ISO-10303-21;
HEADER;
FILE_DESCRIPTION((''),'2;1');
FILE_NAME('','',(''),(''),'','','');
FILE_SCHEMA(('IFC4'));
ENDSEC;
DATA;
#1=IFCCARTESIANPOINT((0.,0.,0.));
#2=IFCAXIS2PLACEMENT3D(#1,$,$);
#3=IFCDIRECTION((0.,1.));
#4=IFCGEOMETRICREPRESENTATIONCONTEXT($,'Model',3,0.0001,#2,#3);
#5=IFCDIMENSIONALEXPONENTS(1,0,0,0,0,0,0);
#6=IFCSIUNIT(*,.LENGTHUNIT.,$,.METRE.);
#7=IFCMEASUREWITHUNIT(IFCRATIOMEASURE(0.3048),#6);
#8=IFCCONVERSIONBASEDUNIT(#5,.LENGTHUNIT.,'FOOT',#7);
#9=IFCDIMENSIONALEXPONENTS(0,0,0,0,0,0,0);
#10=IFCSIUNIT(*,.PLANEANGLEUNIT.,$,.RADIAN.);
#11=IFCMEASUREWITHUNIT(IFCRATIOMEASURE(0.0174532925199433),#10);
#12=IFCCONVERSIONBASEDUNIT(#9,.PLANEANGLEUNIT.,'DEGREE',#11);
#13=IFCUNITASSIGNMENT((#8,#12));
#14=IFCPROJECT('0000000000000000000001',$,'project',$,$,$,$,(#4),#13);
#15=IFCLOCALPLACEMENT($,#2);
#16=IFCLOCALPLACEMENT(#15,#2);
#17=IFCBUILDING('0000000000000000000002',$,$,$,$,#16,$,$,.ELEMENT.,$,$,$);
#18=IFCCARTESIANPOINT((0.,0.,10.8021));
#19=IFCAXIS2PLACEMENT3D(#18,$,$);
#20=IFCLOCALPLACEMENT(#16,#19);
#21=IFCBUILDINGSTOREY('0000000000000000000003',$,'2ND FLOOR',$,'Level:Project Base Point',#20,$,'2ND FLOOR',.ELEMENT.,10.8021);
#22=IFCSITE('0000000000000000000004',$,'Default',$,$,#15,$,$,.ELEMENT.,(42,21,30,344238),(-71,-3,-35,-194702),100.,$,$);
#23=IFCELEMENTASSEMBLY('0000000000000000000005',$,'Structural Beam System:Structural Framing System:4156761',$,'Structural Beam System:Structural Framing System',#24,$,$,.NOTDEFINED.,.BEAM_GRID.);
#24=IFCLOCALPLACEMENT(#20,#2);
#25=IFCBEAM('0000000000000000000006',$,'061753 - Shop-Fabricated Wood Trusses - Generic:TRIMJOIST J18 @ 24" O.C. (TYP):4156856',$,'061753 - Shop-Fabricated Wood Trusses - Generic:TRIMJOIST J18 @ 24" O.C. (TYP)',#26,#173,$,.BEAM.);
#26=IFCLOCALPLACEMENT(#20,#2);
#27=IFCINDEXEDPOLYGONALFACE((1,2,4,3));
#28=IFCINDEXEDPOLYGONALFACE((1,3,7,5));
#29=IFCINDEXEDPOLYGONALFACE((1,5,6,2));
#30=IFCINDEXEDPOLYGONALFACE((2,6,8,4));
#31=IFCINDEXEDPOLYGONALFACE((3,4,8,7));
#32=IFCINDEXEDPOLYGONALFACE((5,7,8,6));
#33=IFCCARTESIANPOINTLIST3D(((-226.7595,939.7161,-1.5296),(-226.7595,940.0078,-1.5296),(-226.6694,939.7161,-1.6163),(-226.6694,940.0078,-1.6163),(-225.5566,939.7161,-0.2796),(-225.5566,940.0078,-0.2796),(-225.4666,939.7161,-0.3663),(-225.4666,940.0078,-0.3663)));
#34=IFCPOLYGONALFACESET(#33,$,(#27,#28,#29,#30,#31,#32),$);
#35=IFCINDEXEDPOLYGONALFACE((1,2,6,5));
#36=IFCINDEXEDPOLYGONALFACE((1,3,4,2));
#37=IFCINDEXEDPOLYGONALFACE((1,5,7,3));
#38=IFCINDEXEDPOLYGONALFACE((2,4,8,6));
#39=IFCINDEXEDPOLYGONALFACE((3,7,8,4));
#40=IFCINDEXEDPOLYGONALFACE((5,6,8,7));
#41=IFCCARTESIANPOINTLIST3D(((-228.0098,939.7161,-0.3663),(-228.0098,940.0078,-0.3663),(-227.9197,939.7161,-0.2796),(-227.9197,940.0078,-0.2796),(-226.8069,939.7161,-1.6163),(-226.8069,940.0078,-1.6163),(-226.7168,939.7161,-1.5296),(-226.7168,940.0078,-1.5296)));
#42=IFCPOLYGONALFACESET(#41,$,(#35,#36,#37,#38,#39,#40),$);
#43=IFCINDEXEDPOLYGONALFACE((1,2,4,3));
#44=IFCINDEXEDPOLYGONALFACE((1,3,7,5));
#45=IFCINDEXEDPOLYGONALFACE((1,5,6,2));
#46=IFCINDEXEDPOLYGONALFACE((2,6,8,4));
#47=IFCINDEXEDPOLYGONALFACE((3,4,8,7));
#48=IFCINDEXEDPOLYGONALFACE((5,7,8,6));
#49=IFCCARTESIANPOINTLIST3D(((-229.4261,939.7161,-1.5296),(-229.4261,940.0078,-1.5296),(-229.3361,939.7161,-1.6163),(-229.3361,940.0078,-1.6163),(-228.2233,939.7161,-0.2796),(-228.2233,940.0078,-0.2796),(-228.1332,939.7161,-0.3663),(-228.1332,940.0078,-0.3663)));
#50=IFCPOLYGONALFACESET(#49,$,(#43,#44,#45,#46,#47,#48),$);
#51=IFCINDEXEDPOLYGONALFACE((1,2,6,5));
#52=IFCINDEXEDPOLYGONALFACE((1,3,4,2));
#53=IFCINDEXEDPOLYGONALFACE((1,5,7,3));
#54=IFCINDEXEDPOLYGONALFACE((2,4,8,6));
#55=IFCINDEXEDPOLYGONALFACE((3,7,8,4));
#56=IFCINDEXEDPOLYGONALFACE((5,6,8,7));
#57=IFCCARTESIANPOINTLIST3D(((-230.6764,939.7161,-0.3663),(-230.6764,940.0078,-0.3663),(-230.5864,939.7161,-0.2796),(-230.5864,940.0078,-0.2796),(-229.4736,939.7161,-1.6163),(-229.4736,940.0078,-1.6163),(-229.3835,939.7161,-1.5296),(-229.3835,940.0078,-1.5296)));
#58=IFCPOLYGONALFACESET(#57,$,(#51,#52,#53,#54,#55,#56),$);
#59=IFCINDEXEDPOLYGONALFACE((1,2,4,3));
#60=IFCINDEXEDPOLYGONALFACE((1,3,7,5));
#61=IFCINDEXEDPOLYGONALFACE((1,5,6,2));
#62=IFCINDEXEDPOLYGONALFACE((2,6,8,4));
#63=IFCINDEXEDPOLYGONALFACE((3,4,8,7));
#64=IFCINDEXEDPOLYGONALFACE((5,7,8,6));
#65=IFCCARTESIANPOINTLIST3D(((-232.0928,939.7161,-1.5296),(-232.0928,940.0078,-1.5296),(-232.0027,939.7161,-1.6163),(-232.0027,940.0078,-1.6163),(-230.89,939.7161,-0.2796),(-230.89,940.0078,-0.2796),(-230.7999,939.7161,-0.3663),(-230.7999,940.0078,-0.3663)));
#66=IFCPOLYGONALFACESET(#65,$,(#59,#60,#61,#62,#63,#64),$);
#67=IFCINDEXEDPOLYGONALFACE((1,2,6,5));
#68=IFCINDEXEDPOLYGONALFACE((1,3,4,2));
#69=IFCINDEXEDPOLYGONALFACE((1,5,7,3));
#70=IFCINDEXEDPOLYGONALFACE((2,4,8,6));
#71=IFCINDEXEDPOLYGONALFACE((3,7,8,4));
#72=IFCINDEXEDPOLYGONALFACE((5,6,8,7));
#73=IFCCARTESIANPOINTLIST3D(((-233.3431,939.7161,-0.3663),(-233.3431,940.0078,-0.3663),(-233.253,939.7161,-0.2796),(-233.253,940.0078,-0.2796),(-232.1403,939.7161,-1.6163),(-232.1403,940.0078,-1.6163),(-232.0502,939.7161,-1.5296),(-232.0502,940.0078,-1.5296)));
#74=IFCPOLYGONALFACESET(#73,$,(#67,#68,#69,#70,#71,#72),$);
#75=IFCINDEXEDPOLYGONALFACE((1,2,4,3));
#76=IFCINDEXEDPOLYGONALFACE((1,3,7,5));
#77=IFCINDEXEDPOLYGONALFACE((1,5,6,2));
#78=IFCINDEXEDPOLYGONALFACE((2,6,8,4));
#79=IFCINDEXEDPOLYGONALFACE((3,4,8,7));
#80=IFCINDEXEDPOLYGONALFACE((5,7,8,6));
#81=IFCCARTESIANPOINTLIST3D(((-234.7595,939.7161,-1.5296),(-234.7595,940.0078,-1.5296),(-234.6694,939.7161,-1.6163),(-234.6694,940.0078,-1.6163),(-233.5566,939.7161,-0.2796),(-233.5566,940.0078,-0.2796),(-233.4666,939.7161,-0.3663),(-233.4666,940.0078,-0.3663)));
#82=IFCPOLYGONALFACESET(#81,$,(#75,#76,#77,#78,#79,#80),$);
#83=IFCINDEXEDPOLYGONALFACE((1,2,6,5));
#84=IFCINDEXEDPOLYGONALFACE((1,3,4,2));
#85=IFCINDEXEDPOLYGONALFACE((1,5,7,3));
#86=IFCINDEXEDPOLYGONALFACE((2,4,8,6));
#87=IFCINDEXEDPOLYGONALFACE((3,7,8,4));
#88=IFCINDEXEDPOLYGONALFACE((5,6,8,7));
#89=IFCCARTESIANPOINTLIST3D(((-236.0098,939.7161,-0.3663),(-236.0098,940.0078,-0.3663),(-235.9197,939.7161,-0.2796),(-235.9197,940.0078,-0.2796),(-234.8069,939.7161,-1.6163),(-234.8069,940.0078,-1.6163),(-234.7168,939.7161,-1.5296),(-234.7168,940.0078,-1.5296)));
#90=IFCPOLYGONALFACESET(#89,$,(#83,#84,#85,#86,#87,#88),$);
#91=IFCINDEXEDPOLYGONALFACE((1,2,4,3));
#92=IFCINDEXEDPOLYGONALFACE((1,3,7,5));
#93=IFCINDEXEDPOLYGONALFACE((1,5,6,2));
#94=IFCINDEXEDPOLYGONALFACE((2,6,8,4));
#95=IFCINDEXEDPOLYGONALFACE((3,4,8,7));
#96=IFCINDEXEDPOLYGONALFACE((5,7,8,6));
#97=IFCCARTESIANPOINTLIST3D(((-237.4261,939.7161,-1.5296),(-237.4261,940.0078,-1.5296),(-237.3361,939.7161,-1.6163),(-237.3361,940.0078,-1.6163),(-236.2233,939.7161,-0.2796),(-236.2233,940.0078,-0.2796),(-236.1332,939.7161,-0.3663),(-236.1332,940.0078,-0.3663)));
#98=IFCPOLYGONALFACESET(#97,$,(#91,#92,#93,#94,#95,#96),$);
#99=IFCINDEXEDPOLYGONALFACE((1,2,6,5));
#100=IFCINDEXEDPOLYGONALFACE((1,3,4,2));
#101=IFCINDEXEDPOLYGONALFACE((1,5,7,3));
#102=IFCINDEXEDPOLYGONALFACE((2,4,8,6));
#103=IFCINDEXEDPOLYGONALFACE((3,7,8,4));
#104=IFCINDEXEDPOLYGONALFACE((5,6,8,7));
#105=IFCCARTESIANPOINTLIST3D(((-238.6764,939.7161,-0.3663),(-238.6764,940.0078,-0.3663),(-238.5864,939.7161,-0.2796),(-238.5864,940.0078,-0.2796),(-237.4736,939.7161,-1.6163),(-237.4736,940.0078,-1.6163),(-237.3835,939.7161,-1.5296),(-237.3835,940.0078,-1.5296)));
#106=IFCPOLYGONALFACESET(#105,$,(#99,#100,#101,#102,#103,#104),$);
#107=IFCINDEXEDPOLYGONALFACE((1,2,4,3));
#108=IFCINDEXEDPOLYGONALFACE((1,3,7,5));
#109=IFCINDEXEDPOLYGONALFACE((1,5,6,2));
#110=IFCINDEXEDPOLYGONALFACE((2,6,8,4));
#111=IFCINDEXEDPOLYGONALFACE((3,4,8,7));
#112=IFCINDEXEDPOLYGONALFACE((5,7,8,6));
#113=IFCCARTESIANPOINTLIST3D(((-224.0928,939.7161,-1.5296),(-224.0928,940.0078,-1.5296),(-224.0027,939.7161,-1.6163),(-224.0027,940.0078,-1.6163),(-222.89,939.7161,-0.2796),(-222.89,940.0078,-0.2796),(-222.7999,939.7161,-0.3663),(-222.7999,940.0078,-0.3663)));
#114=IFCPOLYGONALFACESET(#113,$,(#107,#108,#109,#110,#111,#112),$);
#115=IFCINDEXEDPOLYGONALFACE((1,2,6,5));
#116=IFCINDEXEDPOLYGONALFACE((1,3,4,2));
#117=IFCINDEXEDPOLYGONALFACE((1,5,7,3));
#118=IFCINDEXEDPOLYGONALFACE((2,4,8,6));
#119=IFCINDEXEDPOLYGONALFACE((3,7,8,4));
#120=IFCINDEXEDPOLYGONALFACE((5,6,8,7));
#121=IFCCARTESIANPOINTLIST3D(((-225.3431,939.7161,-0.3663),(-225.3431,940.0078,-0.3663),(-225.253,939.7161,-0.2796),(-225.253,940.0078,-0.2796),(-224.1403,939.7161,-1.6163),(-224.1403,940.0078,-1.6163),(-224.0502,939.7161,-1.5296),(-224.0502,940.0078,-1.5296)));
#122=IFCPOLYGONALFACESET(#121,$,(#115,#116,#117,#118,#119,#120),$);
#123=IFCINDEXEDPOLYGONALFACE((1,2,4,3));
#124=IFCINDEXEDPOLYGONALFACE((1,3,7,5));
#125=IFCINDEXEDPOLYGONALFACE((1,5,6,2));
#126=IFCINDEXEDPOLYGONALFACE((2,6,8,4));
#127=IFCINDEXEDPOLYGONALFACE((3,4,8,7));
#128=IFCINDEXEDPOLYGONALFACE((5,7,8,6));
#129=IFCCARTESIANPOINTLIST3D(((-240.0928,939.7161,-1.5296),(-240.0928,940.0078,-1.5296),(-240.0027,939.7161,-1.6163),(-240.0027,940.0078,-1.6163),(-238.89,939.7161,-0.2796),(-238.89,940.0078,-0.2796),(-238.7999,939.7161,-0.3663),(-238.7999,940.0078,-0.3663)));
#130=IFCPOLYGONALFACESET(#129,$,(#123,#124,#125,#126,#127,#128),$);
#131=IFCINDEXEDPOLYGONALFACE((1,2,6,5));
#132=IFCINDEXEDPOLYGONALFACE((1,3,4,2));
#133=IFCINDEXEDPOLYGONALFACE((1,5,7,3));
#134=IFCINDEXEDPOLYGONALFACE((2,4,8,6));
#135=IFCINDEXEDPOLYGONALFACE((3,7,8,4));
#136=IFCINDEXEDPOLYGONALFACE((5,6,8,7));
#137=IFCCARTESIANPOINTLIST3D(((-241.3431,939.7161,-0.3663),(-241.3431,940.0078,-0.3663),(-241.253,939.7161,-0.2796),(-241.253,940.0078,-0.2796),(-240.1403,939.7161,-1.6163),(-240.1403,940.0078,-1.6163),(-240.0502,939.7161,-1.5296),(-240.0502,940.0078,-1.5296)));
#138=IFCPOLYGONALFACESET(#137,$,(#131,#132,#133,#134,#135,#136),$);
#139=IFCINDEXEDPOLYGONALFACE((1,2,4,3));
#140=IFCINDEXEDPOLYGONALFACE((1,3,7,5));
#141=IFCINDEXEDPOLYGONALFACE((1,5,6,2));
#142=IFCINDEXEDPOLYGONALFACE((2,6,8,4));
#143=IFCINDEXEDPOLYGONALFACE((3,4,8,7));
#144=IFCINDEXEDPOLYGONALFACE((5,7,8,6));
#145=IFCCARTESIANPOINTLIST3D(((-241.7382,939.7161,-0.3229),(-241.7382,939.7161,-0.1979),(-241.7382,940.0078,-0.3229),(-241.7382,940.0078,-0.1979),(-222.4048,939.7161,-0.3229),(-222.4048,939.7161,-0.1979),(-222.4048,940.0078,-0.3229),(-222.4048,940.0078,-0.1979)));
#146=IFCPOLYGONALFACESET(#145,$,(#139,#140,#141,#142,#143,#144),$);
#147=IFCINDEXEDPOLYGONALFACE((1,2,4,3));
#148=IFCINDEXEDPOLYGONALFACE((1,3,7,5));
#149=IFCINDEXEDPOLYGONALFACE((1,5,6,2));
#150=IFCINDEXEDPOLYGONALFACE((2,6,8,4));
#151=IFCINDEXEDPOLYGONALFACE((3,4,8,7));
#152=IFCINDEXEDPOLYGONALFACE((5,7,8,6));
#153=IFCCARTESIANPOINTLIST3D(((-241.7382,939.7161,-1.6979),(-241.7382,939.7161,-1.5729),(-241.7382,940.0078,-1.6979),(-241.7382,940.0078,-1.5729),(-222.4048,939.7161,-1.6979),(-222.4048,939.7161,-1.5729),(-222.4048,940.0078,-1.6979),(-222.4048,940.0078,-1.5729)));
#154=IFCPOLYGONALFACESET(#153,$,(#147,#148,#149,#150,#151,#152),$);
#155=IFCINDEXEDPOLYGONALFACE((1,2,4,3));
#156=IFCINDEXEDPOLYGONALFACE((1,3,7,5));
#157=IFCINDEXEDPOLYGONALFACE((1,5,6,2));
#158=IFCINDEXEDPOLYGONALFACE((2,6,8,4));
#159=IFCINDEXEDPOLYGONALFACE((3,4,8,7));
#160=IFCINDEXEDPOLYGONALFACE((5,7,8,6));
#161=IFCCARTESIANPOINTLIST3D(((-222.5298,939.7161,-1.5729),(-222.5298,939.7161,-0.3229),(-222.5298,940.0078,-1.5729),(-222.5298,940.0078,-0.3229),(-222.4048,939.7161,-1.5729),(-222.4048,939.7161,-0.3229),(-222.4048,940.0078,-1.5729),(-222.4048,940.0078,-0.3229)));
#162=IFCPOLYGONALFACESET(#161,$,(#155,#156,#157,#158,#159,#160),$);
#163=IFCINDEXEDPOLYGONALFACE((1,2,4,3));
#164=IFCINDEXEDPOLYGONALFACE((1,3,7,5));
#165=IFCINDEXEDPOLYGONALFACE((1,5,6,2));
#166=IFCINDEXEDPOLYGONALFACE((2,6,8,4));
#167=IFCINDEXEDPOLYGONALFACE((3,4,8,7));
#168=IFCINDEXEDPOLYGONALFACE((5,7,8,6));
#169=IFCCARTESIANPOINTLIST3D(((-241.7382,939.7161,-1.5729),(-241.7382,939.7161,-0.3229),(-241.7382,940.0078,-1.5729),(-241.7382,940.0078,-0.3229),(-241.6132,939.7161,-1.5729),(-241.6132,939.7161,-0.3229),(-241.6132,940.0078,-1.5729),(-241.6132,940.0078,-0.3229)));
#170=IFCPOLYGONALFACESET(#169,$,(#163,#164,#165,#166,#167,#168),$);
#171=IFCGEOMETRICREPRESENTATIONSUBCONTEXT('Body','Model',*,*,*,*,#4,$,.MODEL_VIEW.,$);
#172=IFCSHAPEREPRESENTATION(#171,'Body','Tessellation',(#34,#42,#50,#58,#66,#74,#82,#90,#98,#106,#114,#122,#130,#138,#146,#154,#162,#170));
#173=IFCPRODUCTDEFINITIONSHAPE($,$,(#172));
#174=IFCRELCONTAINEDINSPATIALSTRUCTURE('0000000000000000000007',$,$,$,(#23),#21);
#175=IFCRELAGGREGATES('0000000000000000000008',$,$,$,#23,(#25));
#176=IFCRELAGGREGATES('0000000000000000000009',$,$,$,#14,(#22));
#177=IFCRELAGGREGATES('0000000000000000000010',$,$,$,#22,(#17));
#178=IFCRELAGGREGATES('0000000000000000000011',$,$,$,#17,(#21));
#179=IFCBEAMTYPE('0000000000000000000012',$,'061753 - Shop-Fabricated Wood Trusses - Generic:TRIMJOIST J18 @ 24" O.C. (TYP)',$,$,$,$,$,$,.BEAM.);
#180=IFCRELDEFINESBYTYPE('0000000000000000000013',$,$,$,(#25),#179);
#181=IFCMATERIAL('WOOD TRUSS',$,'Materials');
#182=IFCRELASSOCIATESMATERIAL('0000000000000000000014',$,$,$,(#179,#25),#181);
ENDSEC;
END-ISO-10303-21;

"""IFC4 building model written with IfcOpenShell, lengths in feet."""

from ifc_helpers import new_model, entity, si_unit, converted_unit, direction, frame, frame_2d, origin, origin_2d_with_axis, place, context, subcontext, project, spatial, rectangle, extrude, source, transform, mapped, material, material_profile, profile_set, profile_usage, type_object, type_shapes, element, aggregate, save


model = new_model("IFC4")

# Units and contexts
model_context = context("Model", 3, precision=0.0001, world=origin(), true_north=direction((0.0, 1.0)))
body_context = subcontext(model_context, "Body", "Model", "MODEL_VIEW")
ifc_project = project(units=[converted_unit("LENGTHUNIT", "FOOT", entity("IfcRatioMeasure", 0.3048), si_unit("LENGTHUNIT", "METRE"), dimensions=[1, 0, 0, 0, 0, 0, 0]), converted_unit("PLANEANGLEUNIT", "DEGREE", entity("IfcRatioMeasure", 0.0174532925199433), si_unit("PLANEANGLEUNIT", "RADIAN"), dimensions=[0, 0, 0, 0, 0, 0, 0])], contexts=[model_context])

# Site, building, storey
site_placement = place(None, origin())
site = spatial("IfcSite", under=ifc_project, at=site_placement, Name="Default", CompositionType="ELEMENT", RefLatitude=(42, 21, 30, 344238), RefLongitude=(-71, -3, -35, -194702), RefElevation=100.0)
building_placement = place(site_placement, origin())
building = spatial("IfcBuilding", under=site, at=building_placement, CompositionType="ELEMENT")
storey_placement = place(building_placement, frame((0.0, 0.0, 10.8021)))
storey = spatial("IfcBuildingStorey", under=building, at=storey_placement, Name="2ND FLOOR", ObjectType="Level:Project Base Point", LongName="2ND FLOOR", CompositionType="ELEMENT", Elevation=10.8021)

# Element assembly, beam
ifc_material_1 = material(Name="WOOD TRUSS", Category="Materials")
ifc_material_profile_1 = material_profile(ifc_material_1, rectangle(XDim=1.7347, YDim=0.125, at=frame_2d((0.0, 0.0), x_axis=(1.0, 0.0))), Name="TRIMJOIST J18 @ 24\" O.C. (TYP)")
ifc_material_profile_2 = material_profile(ifc_material_1, rectangle(XDim=1.7347, YDim=0.125, at=frame_2d((0.0, 0.0), x_axis=(1.0, 0.0))), Name="TRIMJOIST J18 @ 24\" O.C. (TYP)")
ifc_material_profile_3 = material_profile(ifc_material_1, rectangle(XDim=1.7347, YDim=0.125, at=frame_2d((0.0, 0.0), x_axis=(1.0, 0.0))), Name="TRIMJOIST J18 @ 24\" O.C. (TYP)")
ifc_material_profile_4 = material_profile(ifc_material_1, rectangle(XDim=1.7347, YDim=0.125, at=frame_2d((0.0, 0.0), x_axis=(1.0, 0.0))), Name="TRIMJOIST J18 @ 24\" O.C. (TYP)")
ifc_material_profile_5 = material_profile(ifc_material_1, rectangle(XDim=1.7347, YDim=0.125, at=frame_2d((0.0, 0.0), x_axis=(1.0, 0.0))), Name="TRIMJOIST J18 @ 24\" O.C. (TYP)")
ifc_material_profile_6 = material_profile(ifc_material_1, rectangle(XDim=1.7347, YDim=0.125, at=frame_2d((0.0, 0.0), x_axis=(1.0, 0.0))), Name="TRIMJOIST J18 @ 24\" O.C. (TYP)")
ifc_material_profile_7 = material_profile(ifc_material_1, rectangle(XDim=1.7347, YDim=0.125, at=frame_2d((0.0, 0.0), x_axis=(1.0, 0.0))), Name="TRIMJOIST J18 @ 24\" O.C. (TYP)")
ifc_material_profile_8 = material_profile(ifc_material_1, rectangle(XDim=1.7347, YDim=0.125, at=frame_2d((0.0, 0.0), x_axis=(1.0, 0.0))), Name="TRIMJOIST J18 @ 24\" O.C. (TYP)")
ifc_material_profile_9 = material_profile(ifc_material_1, rectangle(XDim=1.7347, YDim=0.125, at=frame_2d((0.0, 0.0), x_axis=(1.0, 0.0))), Name="TRIMJOIST J18 @ 24\" O.C. (TYP)")
ifc_material_profile_10 = material_profile(ifc_material_1, rectangle(XDim=1.7347, YDim=0.125, at=origin_2d_with_axis()), Name="TRIMJOIST J18 @ 24\" O.C. (TYP)")
ifc_material_profile_11 = material_profile(ifc_material_1, rectangle(XDim=0.125, YDim=0.2917, at=origin_2d_with_axis()), Name="TRIMJOIST J18 @ 24\" O.C. (TYP)")
ifc_material_profile_12 = material_profile(ifc_material_1, rectangle(XDim=0.125, YDim=0.2917, at=origin_2d_with_axis()), Name="TRIMJOIST J18 @ 24\" O.C. (TYP)")
ifc_material_profile_13 = material_profile(ifc_material_1, rectangle(XDim=1.25, YDim=0.2917, at=origin_2d_with_axis()), Name="TRIMJOIST J18 @ 24\" O.C. (TYP)")
ifc_material_profile_14 = material_profile(ifc_material_1, rectangle(XDim=1.25, YDim=0.2917, at=origin_2d_with_axis()), Name="TRIMJOIST J18 @ 24\" O.C. (TYP)")
ifc_profile_set_1 = profile_set([ifc_material_profile_1, ifc_material_profile_2, ifc_material_profile_3, ifc_material_profile_4, ifc_material_profile_5, ifc_material_profile_6, ifc_material_profile_7, ifc_material_profile_8, ifc_material_profile_9, ifc_material_profile_10, ifc_material_profile_11, ifc_material_profile_12, ifc_material_profile_13, ifc_material_profile_14], Name="TRIMJOIST J18 @ 24\" O.C. (TYP)")
assembly_1_placement = place(storey_placement, origin())
assembly_1 = element("IfcElementAssembly", 1, at=assembly_1_placement, inside=storey, Name="Structural Beam System:Structural Framing System:4156761", ObjectType="Structural Beam System:Structural Framing System", AssemblyPlace="NOTDEFINED", PredefinedType="BEAM_GRID")
ifc_profile_usage_1 = profile_usage(ifc_profile_set_1, cardinal=8)
beam_type_1 = type_object("IfcBeamType", Name="061753 - Shop-Fabricated Wood Trusses - Generic:TRIMJOIST J18 @ 24\" O.C. (TYP)", PredefinedType="BEAM", material=ifc_profile_set_1)
shared_shape_1 = source(origin(), body_context, "Body", "SweptSolid", [
    extrude(rectangle(XDim=1.7347, YDim=0.125, at=frame_2d((0.0, 0.0), x_axis=(1.0, 0.0))), frame((5.9585, -0.1458, 0.0), z_axis=(0.0, 1.0, 0.0), x_axis=(0.693383, 0.0, 0.720569)), (0.0, 0.0, 1.0), 0.2917),
    extrude(rectangle(XDim=1.7347, YDim=0.125, at=origin_2d_with_axis()), frame((4.7082, -0.1458, 0.0), z_axis=(0.0, 1.0, 0.0), x_axis=(0.693383, 0.0, -0.720569)), (0.0, 0.0, 1.0), 0.2917),
    extrude(rectangle(XDim=1.7347, YDim=0.125, at=frame_2d((0.0, 0.0), x_axis=(1.0, 0.0))), frame((3.2918, -0.1458, 0.0), z_axis=(0.0, 1.0, 0.0), x_axis=(0.693383, 0.0, 0.720569)), (0.0, 0.0, 1.0), 0.2917),
    extrude(rectangle(XDim=1.7347, YDim=0.125, at=frame_2d((0.0, 0.0), x_axis=(1.0, 0.0))), frame((2.0415, -0.1458, 0.0), z_axis=(0.0, 1.0, 0.0), x_axis=(0.693383, 0.0, -0.720569)), (0.0, 0.0, 1.0), 0.2917),
    extrude(rectangle(XDim=1.7347, YDim=0.125, at=frame_2d((0.0, 0.0), x_axis=(1.0, 0.0))), frame((0.6251, -0.1458, 0.0), z_axis=(0.0, 1.0, 0.0), x_axis=(0.693383, 0.0, 0.720569)), (0.0, 0.0, 1.0), 0.2917),
    extrude(rectangle(XDim=1.7347, YDim=0.125, at=frame_2d((0.0, 0.0), x_axis=(1.0, 0.0))), frame((-0.6251, -0.1458, 0.0), z_axis=(0.0, 1.0, 0.0), x_axis=(0.693383, 0.0, -0.720569)), (0.0, 0.0, 1.0), 0.2917),
    extrude(rectangle(XDim=1.7347, YDim=0.125, at=frame_2d((0.0, 0.0), x_axis=(1.0, 0.0))), frame((-2.0415, -0.1458, 0.0), z_axis=(0.0, 1.0, 0.0), x_axis=(0.693383, 0.0, 0.720569)), (0.0, 0.0, 1.0), 0.2917),
    extrude(rectangle(XDim=1.7347, YDim=0.125, at=origin_2d_with_axis()), frame((-3.2918, -0.1458, 0.0), z_axis=(0.0, 1.0, 0.0), x_axis=(0.693383, 0.0, -0.720569)), (0.0, 0.0, 1.0), 0.2917),
    extrude(rectangle(XDim=1.7347, YDim=0.125, at=frame_2d((0.0, 0.0), x_axis=(1.0, 0.0))), frame((-4.7082, -0.1458, 0.0), z_axis=(0.0, 1.0, 0.0), x_axis=(0.693383, 0.0, 0.720569)), (0.0, 0.0, 1.0), 0.2917),
    extrude(rectangle(XDim=1.7347, YDim=0.125, at=frame_2d((0.0, 0.0), x_axis=(1.0, 0.0))), frame((-5.9585, -0.1458, 0.0), z_axis=(0.0, 1.0, 0.0), x_axis=(0.693383, 0.0, -0.720569)), (0.0, 0.0, 1.0), 0.2917),
    extrude(rectangle(XDim=1.7347, YDim=0.125, at=frame_2d((0.0, 0.0), x_axis=(1.0, 0.0))), frame((8.6251, -0.1458, 0.0), z_axis=(0.0, 1.0, 0.0), x_axis=(0.693383, 0.0, 0.720569)), (0.0, 0.0, 1.0), 0.2917),
    extrude(rectangle(XDim=1.7347, YDim=0.125, at=origin_2d_with_axis()), frame((7.3749, -0.1458, 0.0), z_axis=(0.0, 1.0, 0.0), x_axis=(0.693383, 0.0, -0.720569)), (0.0, 0.0, 1.0), 0.2917),
    extrude(rectangle(XDim=1.7347, YDim=0.125, at=frame_2d((0.0, 0.0), x_axis=(1.0, 0.0))), frame((-7.3749, -0.1458, 0.0), z_axis=(0.0, 1.0, 0.0), x_axis=(0.693383, 0.0, 0.720569)), (0.0, 0.0, 1.0), 0.2917),
    extrude(rectangle(XDim=1.7347, YDim=0.125, at=origin_2d_with_axis()), frame((-8.6251, -0.1458, 0.0), z_axis=(0.0, 1.0, 0.0), x_axis=(0.693383, 0.0, -0.720569)), (0.0, 0.0, 1.0), 0.2917),
    extrude(rectangle(XDim=0.125, YDim=0.2917, at=origin_2d_with_axis()), frame((-9.6667, 0.0, 0.6875), z_axis=(1.0, 0.0, 0.0), x_axis=(0.0, 0.0, -1.0)), (0.0, 0.0, 1.0), 19.3333),
    extrude(rectangle(XDim=0.125, YDim=0.2917, at=origin_2d_with_axis()), frame((-9.6667, 0.0, -0.6875), z_axis=(1.0, 0.0, 0.0), x_axis=(0.0, 0.0, -1.0)), (0.0, 0.0, 1.0), 19.3333),
    extrude(rectangle(XDim=1.25, YDim=0.2917, at=origin_2d_with_axis()), frame((9.5417, 0.0, 0.0), z_axis=(1.0, 0.0, 0.0), x_axis=(0.0, 0.0, -1.0)), (0.0, 0.0, 1.0), 0.125),
    extrude(rectangle(XDim=1.25, YDim=0.2917, at=origin_2d_with_axis()), frame((-9.6667, 0.0, 0.0), z_axis=(1.0, 0.0, 0.0), x_axis=(0.0, 0.0, -1.0)), (0.0, 0.0, 1.0), 0.125),
])
type_shapes(beam_type_1, [shared_shape_1])
beam_1_placement = place(assembly_1_placement, frame((-232.0715, 939.8619, -0.9479)))
beam_1 = element("IfcBeam", 2, at=beam_1_placement, type_object=beam_type_1, material=ifc_profile_usage_1, Name="061753 - Shop-Fabricated Wood Trusses - Generic:TRIMJOIST J18 @ 24\" O.C. (TYP):4156856", ObjectType="061753 - Shop-Fabricated Wood Trusses - Generic:TRIMJOIST J18 @ 24\" O.C. (TYP)", PredefinedType="BEAM", context=body_context, shape_type="MappedRepresentation", body=[
    mapped(shared_shape_1, transform((0.0, 0.0, 0.0), scale=1.0)),
])
aggregate(assembly_1, [beam_1])

save(model, "model.ifc")
